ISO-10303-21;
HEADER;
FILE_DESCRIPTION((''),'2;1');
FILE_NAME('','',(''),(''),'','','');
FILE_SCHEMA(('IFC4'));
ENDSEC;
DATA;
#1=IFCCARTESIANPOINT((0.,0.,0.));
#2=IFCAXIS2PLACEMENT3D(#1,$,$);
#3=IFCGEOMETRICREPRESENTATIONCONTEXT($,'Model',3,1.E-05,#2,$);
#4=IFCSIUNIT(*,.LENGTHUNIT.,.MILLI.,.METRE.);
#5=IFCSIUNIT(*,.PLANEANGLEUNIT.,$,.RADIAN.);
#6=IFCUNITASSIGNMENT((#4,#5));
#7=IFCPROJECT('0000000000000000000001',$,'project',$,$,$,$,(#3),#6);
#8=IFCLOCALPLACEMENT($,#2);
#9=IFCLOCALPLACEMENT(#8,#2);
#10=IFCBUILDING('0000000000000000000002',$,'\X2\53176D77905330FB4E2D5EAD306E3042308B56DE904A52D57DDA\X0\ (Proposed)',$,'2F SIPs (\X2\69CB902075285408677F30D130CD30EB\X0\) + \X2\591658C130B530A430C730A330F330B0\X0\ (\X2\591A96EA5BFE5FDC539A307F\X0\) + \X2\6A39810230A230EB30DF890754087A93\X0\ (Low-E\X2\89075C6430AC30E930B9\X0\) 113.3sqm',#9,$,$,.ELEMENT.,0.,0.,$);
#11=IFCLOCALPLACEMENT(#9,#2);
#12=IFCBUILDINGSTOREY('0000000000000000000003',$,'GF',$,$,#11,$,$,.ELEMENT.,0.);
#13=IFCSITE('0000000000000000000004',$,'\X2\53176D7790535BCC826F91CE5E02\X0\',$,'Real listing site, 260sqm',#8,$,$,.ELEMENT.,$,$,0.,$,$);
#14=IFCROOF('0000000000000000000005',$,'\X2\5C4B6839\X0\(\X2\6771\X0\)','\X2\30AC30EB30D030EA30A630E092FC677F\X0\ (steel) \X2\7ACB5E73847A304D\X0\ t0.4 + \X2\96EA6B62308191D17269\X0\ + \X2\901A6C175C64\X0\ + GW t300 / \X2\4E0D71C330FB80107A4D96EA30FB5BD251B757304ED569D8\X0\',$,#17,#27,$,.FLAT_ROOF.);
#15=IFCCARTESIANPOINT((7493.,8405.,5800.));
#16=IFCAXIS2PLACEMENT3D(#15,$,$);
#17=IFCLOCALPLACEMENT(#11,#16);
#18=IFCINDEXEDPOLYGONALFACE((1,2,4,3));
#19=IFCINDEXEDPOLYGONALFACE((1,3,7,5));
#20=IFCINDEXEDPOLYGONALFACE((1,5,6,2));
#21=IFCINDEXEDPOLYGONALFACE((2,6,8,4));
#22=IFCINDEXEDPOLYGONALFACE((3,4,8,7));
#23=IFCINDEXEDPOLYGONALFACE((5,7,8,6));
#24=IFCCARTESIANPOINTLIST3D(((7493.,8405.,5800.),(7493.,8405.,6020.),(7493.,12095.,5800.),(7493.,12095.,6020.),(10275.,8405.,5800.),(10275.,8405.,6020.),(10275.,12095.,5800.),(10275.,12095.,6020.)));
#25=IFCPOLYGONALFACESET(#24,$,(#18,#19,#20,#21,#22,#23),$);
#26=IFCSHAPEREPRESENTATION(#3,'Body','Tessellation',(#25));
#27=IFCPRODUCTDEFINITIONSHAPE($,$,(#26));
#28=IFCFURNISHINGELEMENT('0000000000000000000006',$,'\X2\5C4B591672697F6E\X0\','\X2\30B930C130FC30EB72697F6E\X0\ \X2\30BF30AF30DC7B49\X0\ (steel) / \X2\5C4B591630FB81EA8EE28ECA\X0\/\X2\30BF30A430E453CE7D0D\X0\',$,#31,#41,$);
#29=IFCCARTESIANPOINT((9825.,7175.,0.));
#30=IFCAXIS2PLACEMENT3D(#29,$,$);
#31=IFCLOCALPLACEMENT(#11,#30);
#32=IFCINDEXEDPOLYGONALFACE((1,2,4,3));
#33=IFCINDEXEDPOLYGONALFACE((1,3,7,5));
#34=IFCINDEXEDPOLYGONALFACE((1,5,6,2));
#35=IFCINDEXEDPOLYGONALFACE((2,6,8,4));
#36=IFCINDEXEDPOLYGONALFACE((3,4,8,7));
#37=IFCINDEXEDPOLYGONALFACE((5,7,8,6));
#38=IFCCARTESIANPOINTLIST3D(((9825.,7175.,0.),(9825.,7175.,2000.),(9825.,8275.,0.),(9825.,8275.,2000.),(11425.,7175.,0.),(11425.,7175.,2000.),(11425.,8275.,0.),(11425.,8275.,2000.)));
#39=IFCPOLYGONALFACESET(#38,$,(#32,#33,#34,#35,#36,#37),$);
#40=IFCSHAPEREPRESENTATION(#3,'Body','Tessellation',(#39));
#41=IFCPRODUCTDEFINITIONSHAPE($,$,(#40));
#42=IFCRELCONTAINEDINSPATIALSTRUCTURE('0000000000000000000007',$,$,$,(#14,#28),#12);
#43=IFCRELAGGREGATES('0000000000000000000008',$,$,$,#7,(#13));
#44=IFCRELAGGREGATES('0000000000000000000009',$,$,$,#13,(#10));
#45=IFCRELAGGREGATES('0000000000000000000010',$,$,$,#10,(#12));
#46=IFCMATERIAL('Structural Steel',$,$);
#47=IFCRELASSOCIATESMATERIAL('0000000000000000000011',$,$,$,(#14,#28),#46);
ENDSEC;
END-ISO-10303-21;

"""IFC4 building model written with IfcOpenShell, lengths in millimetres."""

from ifc_helpers import new_model, si_unit, frame, frame_2d, origin, place, context, project, spatial, rectangle, extrude, material, element, save


model = new_model("IFC4")

# Units and contexts
model_context = context("Model", 3, precision=1e-05, world=origin())
ifc_project = project(units=[si_unit("LENGTHUNIT", "METRE", prefix="MILLI"), si_unit("PLANEANGLEUNIT", "RADIAN")], contexts=[model_context])

# Site, building, storey
site_placement = place(None, origin())
site = spatial("IfcSite", under=ifc_project, at=site_placement, Name="北海道富良野市", ObjectType="Real listing site, 260sqm", CompositionType="ELEMENT", RefElevation=0.0)
building_placement = place(site_placement, origin())
building = spatial("IfcBuilding", under=site, at=building_placement, Name="北海道・中庭のある回遊動線 (Proposed)", ObjectType="2F SIPs (構造用合板パネル) + 外壁サイディング (多雪対応厚み) + 樹脂アルミ複合窓 (Low-E複層ガラス) 113.3sqm", CompositionType="ELEMENT", ElevationOfRefHeight=0.0, ElevationOfTerrain=0.0)
storey_placement = place(building_placement, origin())
storey = spatial("IfcBuildingStorey", under=building, at=storey_placement, Name="GF", CompositionType="ELEMENT", Elevation=0.0)

# Roof
ifc_material_1 = material(Name="Structural Steel")
for number, where, name in (
    (1, (7493.0, 8405.0, 5800.0), "屋根(東)"),
):
    element("IfcRoof", number, at=place(storey_placement, frame(where)), inside=storey, material=ifc_material_1, Name=name, Description="ガルバリウム鋼板 (steel) 立平葺き t0.4 + 雪止め金物 + 通気層 + GW t300 / 不燃・耐積雪・寒冷地仕様", PredefinedType="FLAT_ROOF", context=model_context, shape_type="SweptSolid", body=[
        extrude(rectangle(XDim=2782.0, YDim=3690.0, at=frame_2d((1391.0, 1845.0))), frame((7493.0, 8405.0, 5800.0)), (0.0, 0.0, 1.0), 220.0),
    ])

# Furnishing element
furnishing_placement = place(storey_placement, frame((9825.0, 7175.0, 0.0)))
element("IfcFurnishingElement", 2, at=furnishing_placement, inside=storey, material=ifc_material_1, Name="屋外物置", Description="スチール物置 タクボ等 (steel) / 屋外・自転車/タイヤ収納", context=model_context, shape_type="SweptSolid", body=[
    extrude(rectangle(XDim=1600.0, YDim=1100.0, at=frame_2d((800.0, 550.0))), frame((9825.0, 7175.0, 0.0)), (0.0, 0.0, 1.0), 2000.0),
])

save(model, "model.ifc")
